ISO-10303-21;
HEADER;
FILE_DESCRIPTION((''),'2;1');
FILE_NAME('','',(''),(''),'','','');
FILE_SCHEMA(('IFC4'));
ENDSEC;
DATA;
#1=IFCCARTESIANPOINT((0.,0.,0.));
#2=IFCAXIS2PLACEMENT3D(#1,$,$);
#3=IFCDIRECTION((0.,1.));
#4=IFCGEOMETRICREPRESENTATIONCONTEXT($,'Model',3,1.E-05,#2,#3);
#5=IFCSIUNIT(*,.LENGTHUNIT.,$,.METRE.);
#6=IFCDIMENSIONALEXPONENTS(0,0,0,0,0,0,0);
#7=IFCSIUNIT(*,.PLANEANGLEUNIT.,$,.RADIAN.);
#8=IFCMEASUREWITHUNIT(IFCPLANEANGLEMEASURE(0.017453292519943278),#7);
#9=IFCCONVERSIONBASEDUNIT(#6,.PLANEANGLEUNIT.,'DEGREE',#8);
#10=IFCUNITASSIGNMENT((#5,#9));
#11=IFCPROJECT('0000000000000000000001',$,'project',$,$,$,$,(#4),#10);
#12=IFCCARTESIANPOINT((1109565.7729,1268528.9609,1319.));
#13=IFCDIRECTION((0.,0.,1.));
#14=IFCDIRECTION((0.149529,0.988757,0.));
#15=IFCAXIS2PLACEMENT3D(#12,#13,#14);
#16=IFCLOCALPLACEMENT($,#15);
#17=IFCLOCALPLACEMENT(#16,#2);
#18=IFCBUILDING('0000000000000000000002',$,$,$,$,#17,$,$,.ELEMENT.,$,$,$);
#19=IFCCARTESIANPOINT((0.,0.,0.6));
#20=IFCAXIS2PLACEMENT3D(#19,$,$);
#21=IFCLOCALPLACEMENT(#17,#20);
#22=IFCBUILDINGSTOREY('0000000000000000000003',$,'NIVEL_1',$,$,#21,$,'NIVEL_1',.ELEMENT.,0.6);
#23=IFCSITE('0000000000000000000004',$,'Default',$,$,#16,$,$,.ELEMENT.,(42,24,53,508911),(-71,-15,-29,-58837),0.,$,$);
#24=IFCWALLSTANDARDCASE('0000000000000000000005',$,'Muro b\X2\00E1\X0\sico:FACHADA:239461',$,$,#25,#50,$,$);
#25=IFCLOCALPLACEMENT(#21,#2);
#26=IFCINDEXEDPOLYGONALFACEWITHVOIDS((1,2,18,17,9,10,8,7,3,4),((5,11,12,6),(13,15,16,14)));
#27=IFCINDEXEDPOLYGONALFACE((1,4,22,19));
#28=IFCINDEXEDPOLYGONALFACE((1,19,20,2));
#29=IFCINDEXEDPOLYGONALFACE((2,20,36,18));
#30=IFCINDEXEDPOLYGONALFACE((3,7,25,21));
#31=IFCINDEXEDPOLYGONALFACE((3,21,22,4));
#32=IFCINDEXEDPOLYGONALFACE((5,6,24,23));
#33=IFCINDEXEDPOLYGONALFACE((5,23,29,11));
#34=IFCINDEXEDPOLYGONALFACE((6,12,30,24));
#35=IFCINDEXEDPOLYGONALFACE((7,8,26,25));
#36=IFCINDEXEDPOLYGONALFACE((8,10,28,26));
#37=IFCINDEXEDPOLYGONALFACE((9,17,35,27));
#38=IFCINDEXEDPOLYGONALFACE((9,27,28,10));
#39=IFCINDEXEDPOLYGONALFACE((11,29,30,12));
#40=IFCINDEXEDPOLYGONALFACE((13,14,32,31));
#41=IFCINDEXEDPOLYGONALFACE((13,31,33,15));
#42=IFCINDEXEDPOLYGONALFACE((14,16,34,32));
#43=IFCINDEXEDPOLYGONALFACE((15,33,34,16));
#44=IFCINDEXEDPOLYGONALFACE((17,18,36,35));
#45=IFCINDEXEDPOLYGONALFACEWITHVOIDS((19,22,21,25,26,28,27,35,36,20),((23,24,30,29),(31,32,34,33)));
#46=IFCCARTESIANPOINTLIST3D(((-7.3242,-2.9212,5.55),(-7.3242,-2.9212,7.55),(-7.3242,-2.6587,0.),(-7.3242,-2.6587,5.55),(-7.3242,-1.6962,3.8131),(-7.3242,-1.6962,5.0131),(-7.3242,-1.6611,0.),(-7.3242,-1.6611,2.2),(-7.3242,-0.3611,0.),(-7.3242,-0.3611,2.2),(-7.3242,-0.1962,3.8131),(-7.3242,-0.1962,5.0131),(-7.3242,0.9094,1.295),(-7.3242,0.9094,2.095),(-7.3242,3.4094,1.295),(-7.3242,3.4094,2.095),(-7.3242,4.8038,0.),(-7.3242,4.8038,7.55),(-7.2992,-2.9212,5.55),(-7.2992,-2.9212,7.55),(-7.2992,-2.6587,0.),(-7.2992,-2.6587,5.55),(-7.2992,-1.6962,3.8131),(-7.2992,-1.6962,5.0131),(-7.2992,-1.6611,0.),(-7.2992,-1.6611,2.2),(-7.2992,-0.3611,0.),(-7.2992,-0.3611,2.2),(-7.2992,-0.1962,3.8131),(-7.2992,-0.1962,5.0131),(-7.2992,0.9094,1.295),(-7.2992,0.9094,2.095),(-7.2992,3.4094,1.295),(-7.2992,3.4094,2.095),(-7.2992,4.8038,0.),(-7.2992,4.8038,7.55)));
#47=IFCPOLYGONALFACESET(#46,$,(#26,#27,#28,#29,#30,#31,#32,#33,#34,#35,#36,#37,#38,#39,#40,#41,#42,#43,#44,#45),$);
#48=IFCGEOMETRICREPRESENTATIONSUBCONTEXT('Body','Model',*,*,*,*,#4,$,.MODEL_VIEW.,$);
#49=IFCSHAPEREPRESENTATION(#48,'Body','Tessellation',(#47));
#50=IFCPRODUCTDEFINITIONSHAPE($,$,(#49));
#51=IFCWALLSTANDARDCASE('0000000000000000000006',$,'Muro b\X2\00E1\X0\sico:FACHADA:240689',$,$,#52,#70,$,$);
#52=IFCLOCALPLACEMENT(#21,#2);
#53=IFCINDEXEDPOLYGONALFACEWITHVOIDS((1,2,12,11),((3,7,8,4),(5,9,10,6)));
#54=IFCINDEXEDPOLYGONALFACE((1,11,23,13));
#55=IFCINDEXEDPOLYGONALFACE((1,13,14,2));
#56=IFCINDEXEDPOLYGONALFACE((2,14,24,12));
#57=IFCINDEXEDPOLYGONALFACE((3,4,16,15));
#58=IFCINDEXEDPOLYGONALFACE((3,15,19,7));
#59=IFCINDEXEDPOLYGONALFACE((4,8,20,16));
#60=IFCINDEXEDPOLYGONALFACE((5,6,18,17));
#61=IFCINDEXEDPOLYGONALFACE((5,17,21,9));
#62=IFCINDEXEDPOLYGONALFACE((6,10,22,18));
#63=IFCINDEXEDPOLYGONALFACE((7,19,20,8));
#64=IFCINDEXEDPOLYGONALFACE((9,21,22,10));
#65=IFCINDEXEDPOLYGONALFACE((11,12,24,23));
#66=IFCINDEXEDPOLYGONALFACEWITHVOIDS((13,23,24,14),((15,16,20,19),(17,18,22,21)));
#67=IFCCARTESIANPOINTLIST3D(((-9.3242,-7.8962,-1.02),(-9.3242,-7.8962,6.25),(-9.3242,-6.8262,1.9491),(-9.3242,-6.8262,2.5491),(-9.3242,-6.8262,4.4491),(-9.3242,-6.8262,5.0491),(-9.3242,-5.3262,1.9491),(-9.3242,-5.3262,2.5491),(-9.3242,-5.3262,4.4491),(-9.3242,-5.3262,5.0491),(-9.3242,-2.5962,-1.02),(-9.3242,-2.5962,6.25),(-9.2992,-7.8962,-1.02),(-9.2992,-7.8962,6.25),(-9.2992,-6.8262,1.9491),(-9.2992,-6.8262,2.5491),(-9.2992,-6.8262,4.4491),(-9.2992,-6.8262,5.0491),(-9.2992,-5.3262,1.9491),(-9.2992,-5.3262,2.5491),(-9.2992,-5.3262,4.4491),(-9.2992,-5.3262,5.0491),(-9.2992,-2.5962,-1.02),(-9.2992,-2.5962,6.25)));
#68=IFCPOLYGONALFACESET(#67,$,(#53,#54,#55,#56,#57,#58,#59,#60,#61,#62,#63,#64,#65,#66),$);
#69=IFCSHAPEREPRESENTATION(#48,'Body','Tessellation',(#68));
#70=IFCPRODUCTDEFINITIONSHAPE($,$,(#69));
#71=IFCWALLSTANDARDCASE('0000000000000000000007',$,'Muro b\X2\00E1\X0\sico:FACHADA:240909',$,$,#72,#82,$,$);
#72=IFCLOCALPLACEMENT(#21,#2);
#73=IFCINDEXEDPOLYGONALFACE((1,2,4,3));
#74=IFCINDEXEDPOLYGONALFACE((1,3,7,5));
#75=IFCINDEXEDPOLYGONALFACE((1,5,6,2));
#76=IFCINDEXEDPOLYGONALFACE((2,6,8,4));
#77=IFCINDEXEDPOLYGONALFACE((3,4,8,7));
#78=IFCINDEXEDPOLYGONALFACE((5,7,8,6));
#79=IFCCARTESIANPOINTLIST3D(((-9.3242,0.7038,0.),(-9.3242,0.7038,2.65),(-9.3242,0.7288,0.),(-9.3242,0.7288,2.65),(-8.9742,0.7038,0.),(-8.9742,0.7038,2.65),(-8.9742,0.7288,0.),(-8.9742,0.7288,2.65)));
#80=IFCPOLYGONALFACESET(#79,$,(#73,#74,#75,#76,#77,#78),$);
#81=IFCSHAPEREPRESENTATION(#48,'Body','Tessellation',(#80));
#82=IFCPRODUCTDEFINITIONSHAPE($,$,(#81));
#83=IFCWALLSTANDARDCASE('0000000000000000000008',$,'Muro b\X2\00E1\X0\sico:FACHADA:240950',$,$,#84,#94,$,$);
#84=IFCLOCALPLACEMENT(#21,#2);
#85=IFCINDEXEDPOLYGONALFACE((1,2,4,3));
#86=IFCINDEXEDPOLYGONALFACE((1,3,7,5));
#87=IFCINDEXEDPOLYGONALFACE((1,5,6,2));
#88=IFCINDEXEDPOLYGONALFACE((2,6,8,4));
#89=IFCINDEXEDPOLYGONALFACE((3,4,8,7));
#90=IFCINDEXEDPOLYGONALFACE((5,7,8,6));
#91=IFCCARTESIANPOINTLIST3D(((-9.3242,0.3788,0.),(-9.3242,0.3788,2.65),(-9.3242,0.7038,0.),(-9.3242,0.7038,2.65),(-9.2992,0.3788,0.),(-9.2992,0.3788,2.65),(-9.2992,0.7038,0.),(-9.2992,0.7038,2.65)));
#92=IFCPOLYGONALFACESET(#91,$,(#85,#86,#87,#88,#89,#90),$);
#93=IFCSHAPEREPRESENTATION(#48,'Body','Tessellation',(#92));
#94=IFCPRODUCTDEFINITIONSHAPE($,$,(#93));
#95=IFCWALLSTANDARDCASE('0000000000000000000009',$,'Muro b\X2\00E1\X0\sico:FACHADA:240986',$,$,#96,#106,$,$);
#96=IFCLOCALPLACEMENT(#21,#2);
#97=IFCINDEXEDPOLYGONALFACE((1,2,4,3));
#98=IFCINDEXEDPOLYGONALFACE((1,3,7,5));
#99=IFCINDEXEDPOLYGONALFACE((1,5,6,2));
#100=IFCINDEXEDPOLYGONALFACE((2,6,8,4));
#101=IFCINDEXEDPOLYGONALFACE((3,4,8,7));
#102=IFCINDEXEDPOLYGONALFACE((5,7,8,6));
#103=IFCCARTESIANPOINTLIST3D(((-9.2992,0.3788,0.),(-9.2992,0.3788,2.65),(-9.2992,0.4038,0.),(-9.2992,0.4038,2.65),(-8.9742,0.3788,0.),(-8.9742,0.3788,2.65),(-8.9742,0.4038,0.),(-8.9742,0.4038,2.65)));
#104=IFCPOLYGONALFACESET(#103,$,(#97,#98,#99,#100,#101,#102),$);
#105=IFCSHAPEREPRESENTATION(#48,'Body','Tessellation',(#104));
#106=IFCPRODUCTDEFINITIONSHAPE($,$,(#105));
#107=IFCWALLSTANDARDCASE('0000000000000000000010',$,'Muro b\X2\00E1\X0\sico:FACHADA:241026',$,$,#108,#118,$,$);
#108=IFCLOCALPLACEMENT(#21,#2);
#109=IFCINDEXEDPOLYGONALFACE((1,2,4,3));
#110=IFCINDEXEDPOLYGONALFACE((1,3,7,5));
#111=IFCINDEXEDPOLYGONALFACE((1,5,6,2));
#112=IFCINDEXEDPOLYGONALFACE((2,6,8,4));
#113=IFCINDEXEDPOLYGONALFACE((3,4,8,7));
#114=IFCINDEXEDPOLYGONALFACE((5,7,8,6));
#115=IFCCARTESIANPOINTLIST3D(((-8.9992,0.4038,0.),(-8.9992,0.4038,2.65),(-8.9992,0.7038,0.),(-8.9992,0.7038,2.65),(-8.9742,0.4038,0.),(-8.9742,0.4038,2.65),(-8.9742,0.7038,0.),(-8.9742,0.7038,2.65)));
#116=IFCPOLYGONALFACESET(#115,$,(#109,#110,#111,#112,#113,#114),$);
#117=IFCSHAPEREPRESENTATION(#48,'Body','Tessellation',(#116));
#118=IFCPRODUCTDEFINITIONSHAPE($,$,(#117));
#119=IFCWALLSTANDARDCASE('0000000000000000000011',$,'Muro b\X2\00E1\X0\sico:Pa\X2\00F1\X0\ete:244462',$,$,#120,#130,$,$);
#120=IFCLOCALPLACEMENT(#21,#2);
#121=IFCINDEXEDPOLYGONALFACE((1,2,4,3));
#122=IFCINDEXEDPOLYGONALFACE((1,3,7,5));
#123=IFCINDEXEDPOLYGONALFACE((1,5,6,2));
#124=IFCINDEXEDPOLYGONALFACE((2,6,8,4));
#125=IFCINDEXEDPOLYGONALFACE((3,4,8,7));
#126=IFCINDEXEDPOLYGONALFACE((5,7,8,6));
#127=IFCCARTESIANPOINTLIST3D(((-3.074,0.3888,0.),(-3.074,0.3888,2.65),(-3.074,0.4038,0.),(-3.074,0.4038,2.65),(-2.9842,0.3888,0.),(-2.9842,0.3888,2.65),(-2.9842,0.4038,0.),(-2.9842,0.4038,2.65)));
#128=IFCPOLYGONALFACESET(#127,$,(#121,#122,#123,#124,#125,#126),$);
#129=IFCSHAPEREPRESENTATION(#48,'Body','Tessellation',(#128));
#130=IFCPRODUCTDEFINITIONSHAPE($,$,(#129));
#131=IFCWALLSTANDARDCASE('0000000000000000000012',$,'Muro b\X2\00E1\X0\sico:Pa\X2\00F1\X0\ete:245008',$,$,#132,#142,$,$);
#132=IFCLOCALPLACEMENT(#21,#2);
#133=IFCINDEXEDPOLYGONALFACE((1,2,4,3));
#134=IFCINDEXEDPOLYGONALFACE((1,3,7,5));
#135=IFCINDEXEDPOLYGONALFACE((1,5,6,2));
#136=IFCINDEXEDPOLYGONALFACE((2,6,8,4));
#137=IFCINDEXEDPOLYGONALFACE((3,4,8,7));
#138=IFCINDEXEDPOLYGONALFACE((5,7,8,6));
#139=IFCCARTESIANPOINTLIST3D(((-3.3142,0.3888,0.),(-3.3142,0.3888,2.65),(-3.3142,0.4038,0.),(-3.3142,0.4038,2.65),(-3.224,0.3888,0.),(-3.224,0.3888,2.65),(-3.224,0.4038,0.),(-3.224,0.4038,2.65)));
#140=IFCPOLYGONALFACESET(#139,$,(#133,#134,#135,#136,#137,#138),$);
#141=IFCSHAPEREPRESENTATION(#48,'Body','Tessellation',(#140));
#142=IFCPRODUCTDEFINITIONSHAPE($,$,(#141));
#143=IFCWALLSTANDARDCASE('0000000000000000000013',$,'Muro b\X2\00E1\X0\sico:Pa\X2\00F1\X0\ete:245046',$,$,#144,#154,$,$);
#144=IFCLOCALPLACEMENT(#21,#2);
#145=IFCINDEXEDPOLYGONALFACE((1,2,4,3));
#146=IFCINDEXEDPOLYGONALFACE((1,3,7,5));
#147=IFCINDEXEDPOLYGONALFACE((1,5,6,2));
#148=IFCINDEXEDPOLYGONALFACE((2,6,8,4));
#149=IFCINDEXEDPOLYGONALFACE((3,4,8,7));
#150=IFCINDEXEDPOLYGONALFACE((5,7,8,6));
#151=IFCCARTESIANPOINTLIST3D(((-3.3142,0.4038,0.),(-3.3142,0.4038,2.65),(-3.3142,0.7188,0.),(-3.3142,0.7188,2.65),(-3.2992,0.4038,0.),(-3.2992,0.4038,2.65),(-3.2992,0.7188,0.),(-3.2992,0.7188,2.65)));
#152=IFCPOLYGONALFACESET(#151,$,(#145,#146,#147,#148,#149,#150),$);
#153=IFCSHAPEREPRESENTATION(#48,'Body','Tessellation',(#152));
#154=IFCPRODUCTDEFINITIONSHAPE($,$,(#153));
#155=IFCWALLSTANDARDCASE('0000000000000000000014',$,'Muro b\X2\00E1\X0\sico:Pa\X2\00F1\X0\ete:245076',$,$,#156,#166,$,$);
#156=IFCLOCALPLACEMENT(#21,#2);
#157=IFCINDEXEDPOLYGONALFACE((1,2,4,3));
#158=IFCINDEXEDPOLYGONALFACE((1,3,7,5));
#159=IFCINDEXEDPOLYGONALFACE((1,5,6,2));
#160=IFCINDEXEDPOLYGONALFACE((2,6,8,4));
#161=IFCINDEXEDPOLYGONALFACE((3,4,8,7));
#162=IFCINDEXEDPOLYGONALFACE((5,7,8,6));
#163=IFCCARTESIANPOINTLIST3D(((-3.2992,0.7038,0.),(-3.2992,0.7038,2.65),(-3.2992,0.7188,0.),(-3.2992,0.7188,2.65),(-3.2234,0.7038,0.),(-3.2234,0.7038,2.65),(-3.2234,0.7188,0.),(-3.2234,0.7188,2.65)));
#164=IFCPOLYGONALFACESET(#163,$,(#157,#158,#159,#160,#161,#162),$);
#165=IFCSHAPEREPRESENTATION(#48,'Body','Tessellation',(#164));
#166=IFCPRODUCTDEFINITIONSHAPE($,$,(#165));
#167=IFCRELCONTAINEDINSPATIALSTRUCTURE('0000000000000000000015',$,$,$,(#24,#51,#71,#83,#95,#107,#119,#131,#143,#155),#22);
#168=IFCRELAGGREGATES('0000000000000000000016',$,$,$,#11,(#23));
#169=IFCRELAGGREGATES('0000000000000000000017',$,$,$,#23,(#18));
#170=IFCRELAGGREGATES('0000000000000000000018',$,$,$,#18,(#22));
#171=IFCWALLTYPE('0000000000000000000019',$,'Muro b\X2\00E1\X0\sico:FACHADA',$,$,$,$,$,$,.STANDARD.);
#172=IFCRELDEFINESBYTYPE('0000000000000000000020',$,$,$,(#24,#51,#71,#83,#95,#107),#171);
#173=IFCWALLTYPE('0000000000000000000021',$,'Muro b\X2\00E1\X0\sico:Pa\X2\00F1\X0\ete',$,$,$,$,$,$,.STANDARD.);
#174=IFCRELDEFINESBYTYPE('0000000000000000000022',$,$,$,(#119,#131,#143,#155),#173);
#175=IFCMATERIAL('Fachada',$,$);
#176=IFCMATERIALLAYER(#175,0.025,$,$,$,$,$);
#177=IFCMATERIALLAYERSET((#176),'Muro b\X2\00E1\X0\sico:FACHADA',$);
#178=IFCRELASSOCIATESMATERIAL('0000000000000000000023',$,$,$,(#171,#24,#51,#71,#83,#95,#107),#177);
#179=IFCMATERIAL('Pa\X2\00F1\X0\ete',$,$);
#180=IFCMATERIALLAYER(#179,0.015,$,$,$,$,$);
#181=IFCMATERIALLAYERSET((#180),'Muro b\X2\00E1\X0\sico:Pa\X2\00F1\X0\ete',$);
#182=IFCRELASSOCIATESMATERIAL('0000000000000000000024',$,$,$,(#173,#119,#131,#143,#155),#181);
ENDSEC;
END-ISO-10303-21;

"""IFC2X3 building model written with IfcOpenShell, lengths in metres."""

from ifc_helpers import new_model, entity, si_unit, converted_unit, direction, frame, frame_2d, origin, place, context, subcontext, project, spatial, rectangle, extrude, material, layer, layer_set, layer_usage, type_object, element, save


model = new_model("IFC2X3")

# Units and contexts
model_context = context("Model", 3, precision=1e-05, world=origin(), true_north=direction((0.0, 1.0)))
body_context = subcontext(model_context, "Body", "Model", "MODEL_VIEW")
ifc_project = project(units=[si_unit("LENGTHUNIT", "METRE"), converted_unit("PLANEANGLEUNIT", "DEGREE", entity("IfcPlaneAngleMeasure", 0.017453292519943278), si_unit("PLANEANGLEUNIT", "RADIAN"), dimensions=[0, 0, 0, 0, 0, 0, 0])], contexts=[model_context])

# Site, building, storey
site_placement = place(None, frame((1109565.7729, 1268528.9609, 1319.0), z_axis=(0.0, 0.0, 1.0), x_axis=(0.149529, 0.988757, 0.0)))
site = spatial("IfcSite", under=ifc_project, at=site_placement, Name="Default", CompositionType="ELEMENT", RefLatitude=(42, 24, 53, 508911), RefLongitude=(-71, -15, -29, -58837), RefElevation=0.0)
building_placement = place(site_placement, origin())
building = spatial("IfcBuilding", under=site, at=building_placement, CompositionType="ELEMENT")
storey_placement = place(building_placement, frame((0.0, 0.0, 0.6)))
storey = spatial("IfcBuildingStorey", under=building, at=storey_placement, Name="NIVEL_1", LongName="NIVEL_1", CompositionType="ELEMENT", Elevation=0.6)

# Shared definitions
ifc_material_1 = material(Name="Pañete")

# Walls, openings
ifc_material_2 = material(Name="Fachada")
ifc_layer_1 = layer(ifc_material_2, 0.025)
ifc_layer_set_1 = layer_set([ifc_layer_1], Name="Muro básico:FACHADA")
ifc_layer_usage_1 = layer_usage(ifc_layer_set_1, "AXIS2", "POSITIVE", -0.0125)
wall_type_1 = type_object("IfcWallType", Name="Muro básico:FACHADA", PredefinedType="STANDARD", material=ifc_layer_set_1)
wall_1_placement = place(storey_placement, frame((-7.3117, 4.8038, 0.0), z_axis=(0.0, 0.0, 1.0), x_axis=(0.0, -1.0, 0.0)))
wall_1 = element("IfcWallStandardCase", 1, at=wall_1_placement, inside=storey, type_object=wall_type_1, material=ifc_layer_usage_1, Name="Muro básico:FACHADA:239461", context=body_context, shape_type="SweptSolid", body=[
    extrude(rectangle(XDim=7.725, YDim=0.025, at=frame_2d((3.8625, 0.0), x_axis=(-1.0, 0.0))), origin(), (0.0, 0.0, 1.0), 7.55),
])
opening_1_placement = place(wall_1_placement, origin())
element("IfcOpeningElement", 2, at=opening_1_placement, cuts=wall_1, ObjectType="Opening", context=body_context, shape_type="SweptSolid", body=[
    extrude(rectangle(XDim=0.8, YDim=2.5, at=frame_2d((0.0, 0.0), x_axis=(0.0, 1.0))), frame((2.6444, 0.0125, 1.695), z_axis=(0.0, -1.0, 0.0), x_axis=(-1.0, 0.0, 0.0)), (0.0, 0.0, 1.0), 0.025),
])
opening_2_placement = place(wall_1_placement, origin())
element("IfcOpeningElement", 3, at=opening_2_placement, cuts=wall_1, ObjectType="Opening", context=body_context, shape_type="SweptSolid", body=[
    extrude(rectangle(XDim=1.2, YDim=1.5, at=frame_2d((0.0, 0.0), x_axis=(0.0, 1.0))), frame((5.75, 0.0125, 4.4131), z_axis=(0.0, -1.0, 0.0), x_axis=(-1.0, 0.0, 0.0)), (0.0, 0.0, 1.0), 0.025),
])
opening_3_placement = place(wall_1_placement, origin())
element("IfcOpeningElement", 4, at=opening_3_placement, cuts=wall_1, ObjectType="Opening", context=body_context, shape_type="SweptSolid", body=[
    extrude(rectangle(XDim=2.2, YDim=1.3, at=frame_2d((0.0, 0.0), x_axis=(0.0, 1.0))), frame((5.8149, 0.0125, 1.1), z_axis=(0.0, -1.0, 0.0), x_axis=(1.0, 0.0, 0.0)), (0.0, 0.0, 1.0), 0.025),
])
opening_4_placement = place(wall_1_placement, origin())
element("IfcOpeningElement", 5, at=opening_4_placement, cuts=wall_1, ObjectType="Opening", context=body_context, shape_type="SweptSolid", body=[
    extrude(rectangle(XDim=5.55, YDim=0.2625, at=frame_2d((0.0, 0.0), x_axis=(0.0, 1.0))), frame((7.5938, 0.0125, 2.775), z_axis=(0.0, -1.0, 0.0), x_axis=(1.0, 0.0, 0.0)), (0.0, 0.0, 1.0), 0.025),
])
ifc_layer_usage_2 = layer_usage(ifc_layer_set_1, "AXIS2", "POSITIVE", -0.0125)
wall_2_placement = place(storey_placement, frame((-9.3117, -2.5962, -1.02), z_axis=(0.0, 0.0, 1.0), x_axis=(0.0, -1.0, 0.0)))
wall_2 = element("IfcWallStandardCase", 6, at=wall_2_placement, inside=storey, type_object=wall_type_1, material=ifc_layer_usage_2, Name="Muro básico:FACHADA:240689", context=body_context, shape_type="SweptSolid", body=[
    extrude(rectangle(XDim=5.3, YDim=0.025, at=frame_2d((2.65, 0.0), x_axis=(-1.0, 0.0))), origin(), (0.0, 0.0, 1.0), 7.27),
])
opening_5_placement = place(wall_2_placement, origin())
element("IfcOpeningElement", 7, at=opening_5_placement, cuts=wall_2, ObjectType="Opening", context=body_context, shape_type="SweptSolid", body=[
    extrude(rectangle(XDim=0.6, YDim=1.5, at=frame_2d((0.0, 0.0), x_axis=(0.0, 1.0))), frame((3.48, 0.0125, 3.2691), z_axis=(0.0, -1.0, 0.0), x_axis=(-1.0, 0.0, 0.0)), (0.0, 0.0, 1.0), 0.025),
])
opening_6_placement = place(wall_2_placement, origin())
element("IfcOpeningElement", 8, at=opening_6_placement, cuts=wall_2, ObjectType="Opening", context=body_context, shape_type="SweptSolid", body=[
    extrude(rectangle(XDim=0.6, YDim=1.5, at=frame_2d((0.0, 0.0), x_axis=(0.0, 1.0))), frame((3.48, 0.0125, 5.7691), z_axis=(0.0, -1.0, 0.0), x_axis=(-1.0, 0.0, 0.0)), (0.0, 0.0, 1.0), 0.025),
])

# Walls
ifc_layer_usage_3 = layer_usage(ifc_layer_set_1, "AXIS2", "POSITIVE", -0.0125)
wall_3_placement = place(storey_placement, frame((-8.9742, 0.7163, 0.0), z_axis=(0.0, 0.0, 1.0), x_axis=(-1.0, 0.0, 0.0)))
element("IfcWallStandardCase", 9, at=wall_3_placement, inside=storey, type_object=wall_type_1, material=ifc_layer_usage_3, Name="Muro básico:FACHADA:240909", context=body_context, shape_type="SweptSolid", body=[
    extrude(rectangle(XDim=0.35, YDim=0.025, at=frame_2d((0.175, 0.0), x_axis=(-1.0, 0.0))), origin(), (0.0, 0.0, 1.0), 2.65),
])
ifc_layer_usage_4 = layer_usage(ifc_layer_set_1, "AXIS2", "POSITIVE", -0.0125)
wall_4_placement = place(storey_placement, frame((-9.3117, 0.7038, 0.0), z_axis=(0.0, 0.0, 1.0), x_axis=(0.0, -1.0, 0.0)))
element("IfcWallStandardCase", 10, at=wall_4_placement, inside=storey, type_object=wall_type_1, material=ifc_layer_usage_4, Name="Muro básico:FACHADA:240950", context=body_context, shape_type="SweptSolid", body=[
    extrude(rectangle(XDim=0.325, YDim=0.025, at=frame_2d((0.1625, 0.0), x_axis=(-1.0, 0.0))), origin(), (0.0, 0.0, 1.0), 2.65),
])
ifc_layer_usage_5 = layer_usage(ifc_layer_set_1, "AXIS2", "POSITIVE", -0.0125)
wall_5_placement = place(storey_placement, frame((-9.2992, 0.3913, 0.0)))
element("IfcWallStandardCase", 11, at=wall_5_placement, inside=storey, type_object=wall_type_1, material=ifc_layer_usage_5, Name="Muro básico:FACHADA:240986", context=body_context, shape_type="SweptSolid", body=[
    extrude(rectangle(XDim=0.325, YDim=0.025, at=frame_2d((0.1625, 0.0), x_axis=(-1.0, 0.0))), origin(), (0.0, 0.0, 1.0), 2.65),
])
ifc_layer_usage_6 = layer_usage(ifc_layer_set_1, "AXIS2", "POSITIVE", -0.0125)
wall_6_placement = place(storey_placement, frame((-8.9867, 0.4038, 0.0), z_axis=(0.0, 0.0, 1.0), x_axis=(0.0, 1.0, 0.0)))
element("IfcWallStandardCase", 12, at=wall_6_placement, inside=storey, type_object=wall_type_1, material=ifc_layer_usage_6, Name="Muro básico:FACHADA:241026", context=body_context, shape_type="SweptSolid", body=[
    extrude(rectangle(XDim=0.3, YDim=0.025, at=frame_2d((0.15, 0.0), x_axis=(-1.0, 0.0))), origin(), (0.0, 0.0, 1.0), 2.65),
])
ifc_layer_2 = layer(ifc_material_1, 0.015)
ifc_layer_set_2 = layer_set([ifc_layer_2], Name="Muro básico:Pañete")
ifc_layer_usage_7 = layer_usage(ifc_layer_set_2, "AXIS2", "POSITIVE", -0.0075)
wall_type_2 = type_object("IfcWallType", Name="Muro básico:Pañete", PredefinedType="STANDARD", material=ifc_layer_set_2)
wall_7_placement = place(storey_placement, frame((-3.074, 0.3963, 0.0)))
element("IfcWallStandardCase", 13, at=wall_7_placement, inside=storey, type_object=wall_type_2, material=ifc_layer_usage_7, Name="Muro básico:Pañete:244462", context=body_context, shape_type="SweptSolid", body=[
    extrude(rectangle(XDim=0.0898, YDim=0.015, at=frame_2d((0.0449, 0.0), x_axis=(-1.0, 0.0))), origin(), (0.0, 0.0, 1.0), 2.65),
])
ifc_layer_usage_8 = layer_usage(ifc_layer_set_2, "AXIS2", "NEGATIVE", 0.0075)
wall_8_placement = place(storey_placement, frame((-3.224, 0.3963, 0.0), z_axis=(0.0, 0.0, 1.0), x_axis=(-1.0, 0.0, 0.0)))
element("IfcWallStandardCase", 14, at=wall_8_placement, inside=storey, type_object=wall_type_2, material=ifc_layer_usage_8, Name="Muro básico:Pañete:245008", context=body_context, shape_type="SweptSolid", body=[
    extrude(rectangle(XDim=0.0902, YDim=0.015, at=frame_2d((0.0451, 0.0), x_axis=(-1.0, 0.0))), origin(), (0.0, 0.0, 1.0), 2.65),
])
ifc_layer_usage_9 = layer_usage(ifc_layer_set_2, "AXIS2", "NEGATIVE", 0.0075)
wall_9_placement = place(storey_placement, frame((-3.3067, 0.4038, 0.0), z_axis=(0.0, 0.0, 1.0), x_axis=(0.0, 1.0, 0.0)))
element("IfcWallStandardCase", 15, at=wall_9_placement, inside=storey, type_object=wall_type_2, material=ifc_layer_usage_9, Name="Muro básico:Pañete:245046", context=body_context, shape_type="SweptSolid", body=[
    extrude(rectangle(XDim=0.315, YDim=0.015, at=frame_2d((0.1575, 0.0), x_axis=(-1.0, 0.0))), origin(), (0.0, 0.0, 1.0), 2.65),
])
ifc_layer_usage_10 = layer_usage(ifc_layer_set_2, "AXIS2", "NEGATIVE", 0.0075)
wall_10_placement = place(storey_placement, frame((-3.2992, 0.7113, 0.0)))
element("IfcWallStandardCase", 16, at=wall_10_placement, inside=storey, type_object=wall_type_2, material=ifc_layer_usage_10, Name="Muro básico:Pañete:245076", context=body_context, shape_type="SweptSolid", body=[
    extrude(rectangle(XDim=0.0759, YDim=0.015, at=frame_2d((0.0379, 0.0), x_axis=(-1.0, 0.0))), origin(), (0.0, 0.0, 1.0), 2.65),
])

save(model, "model.ifc")
